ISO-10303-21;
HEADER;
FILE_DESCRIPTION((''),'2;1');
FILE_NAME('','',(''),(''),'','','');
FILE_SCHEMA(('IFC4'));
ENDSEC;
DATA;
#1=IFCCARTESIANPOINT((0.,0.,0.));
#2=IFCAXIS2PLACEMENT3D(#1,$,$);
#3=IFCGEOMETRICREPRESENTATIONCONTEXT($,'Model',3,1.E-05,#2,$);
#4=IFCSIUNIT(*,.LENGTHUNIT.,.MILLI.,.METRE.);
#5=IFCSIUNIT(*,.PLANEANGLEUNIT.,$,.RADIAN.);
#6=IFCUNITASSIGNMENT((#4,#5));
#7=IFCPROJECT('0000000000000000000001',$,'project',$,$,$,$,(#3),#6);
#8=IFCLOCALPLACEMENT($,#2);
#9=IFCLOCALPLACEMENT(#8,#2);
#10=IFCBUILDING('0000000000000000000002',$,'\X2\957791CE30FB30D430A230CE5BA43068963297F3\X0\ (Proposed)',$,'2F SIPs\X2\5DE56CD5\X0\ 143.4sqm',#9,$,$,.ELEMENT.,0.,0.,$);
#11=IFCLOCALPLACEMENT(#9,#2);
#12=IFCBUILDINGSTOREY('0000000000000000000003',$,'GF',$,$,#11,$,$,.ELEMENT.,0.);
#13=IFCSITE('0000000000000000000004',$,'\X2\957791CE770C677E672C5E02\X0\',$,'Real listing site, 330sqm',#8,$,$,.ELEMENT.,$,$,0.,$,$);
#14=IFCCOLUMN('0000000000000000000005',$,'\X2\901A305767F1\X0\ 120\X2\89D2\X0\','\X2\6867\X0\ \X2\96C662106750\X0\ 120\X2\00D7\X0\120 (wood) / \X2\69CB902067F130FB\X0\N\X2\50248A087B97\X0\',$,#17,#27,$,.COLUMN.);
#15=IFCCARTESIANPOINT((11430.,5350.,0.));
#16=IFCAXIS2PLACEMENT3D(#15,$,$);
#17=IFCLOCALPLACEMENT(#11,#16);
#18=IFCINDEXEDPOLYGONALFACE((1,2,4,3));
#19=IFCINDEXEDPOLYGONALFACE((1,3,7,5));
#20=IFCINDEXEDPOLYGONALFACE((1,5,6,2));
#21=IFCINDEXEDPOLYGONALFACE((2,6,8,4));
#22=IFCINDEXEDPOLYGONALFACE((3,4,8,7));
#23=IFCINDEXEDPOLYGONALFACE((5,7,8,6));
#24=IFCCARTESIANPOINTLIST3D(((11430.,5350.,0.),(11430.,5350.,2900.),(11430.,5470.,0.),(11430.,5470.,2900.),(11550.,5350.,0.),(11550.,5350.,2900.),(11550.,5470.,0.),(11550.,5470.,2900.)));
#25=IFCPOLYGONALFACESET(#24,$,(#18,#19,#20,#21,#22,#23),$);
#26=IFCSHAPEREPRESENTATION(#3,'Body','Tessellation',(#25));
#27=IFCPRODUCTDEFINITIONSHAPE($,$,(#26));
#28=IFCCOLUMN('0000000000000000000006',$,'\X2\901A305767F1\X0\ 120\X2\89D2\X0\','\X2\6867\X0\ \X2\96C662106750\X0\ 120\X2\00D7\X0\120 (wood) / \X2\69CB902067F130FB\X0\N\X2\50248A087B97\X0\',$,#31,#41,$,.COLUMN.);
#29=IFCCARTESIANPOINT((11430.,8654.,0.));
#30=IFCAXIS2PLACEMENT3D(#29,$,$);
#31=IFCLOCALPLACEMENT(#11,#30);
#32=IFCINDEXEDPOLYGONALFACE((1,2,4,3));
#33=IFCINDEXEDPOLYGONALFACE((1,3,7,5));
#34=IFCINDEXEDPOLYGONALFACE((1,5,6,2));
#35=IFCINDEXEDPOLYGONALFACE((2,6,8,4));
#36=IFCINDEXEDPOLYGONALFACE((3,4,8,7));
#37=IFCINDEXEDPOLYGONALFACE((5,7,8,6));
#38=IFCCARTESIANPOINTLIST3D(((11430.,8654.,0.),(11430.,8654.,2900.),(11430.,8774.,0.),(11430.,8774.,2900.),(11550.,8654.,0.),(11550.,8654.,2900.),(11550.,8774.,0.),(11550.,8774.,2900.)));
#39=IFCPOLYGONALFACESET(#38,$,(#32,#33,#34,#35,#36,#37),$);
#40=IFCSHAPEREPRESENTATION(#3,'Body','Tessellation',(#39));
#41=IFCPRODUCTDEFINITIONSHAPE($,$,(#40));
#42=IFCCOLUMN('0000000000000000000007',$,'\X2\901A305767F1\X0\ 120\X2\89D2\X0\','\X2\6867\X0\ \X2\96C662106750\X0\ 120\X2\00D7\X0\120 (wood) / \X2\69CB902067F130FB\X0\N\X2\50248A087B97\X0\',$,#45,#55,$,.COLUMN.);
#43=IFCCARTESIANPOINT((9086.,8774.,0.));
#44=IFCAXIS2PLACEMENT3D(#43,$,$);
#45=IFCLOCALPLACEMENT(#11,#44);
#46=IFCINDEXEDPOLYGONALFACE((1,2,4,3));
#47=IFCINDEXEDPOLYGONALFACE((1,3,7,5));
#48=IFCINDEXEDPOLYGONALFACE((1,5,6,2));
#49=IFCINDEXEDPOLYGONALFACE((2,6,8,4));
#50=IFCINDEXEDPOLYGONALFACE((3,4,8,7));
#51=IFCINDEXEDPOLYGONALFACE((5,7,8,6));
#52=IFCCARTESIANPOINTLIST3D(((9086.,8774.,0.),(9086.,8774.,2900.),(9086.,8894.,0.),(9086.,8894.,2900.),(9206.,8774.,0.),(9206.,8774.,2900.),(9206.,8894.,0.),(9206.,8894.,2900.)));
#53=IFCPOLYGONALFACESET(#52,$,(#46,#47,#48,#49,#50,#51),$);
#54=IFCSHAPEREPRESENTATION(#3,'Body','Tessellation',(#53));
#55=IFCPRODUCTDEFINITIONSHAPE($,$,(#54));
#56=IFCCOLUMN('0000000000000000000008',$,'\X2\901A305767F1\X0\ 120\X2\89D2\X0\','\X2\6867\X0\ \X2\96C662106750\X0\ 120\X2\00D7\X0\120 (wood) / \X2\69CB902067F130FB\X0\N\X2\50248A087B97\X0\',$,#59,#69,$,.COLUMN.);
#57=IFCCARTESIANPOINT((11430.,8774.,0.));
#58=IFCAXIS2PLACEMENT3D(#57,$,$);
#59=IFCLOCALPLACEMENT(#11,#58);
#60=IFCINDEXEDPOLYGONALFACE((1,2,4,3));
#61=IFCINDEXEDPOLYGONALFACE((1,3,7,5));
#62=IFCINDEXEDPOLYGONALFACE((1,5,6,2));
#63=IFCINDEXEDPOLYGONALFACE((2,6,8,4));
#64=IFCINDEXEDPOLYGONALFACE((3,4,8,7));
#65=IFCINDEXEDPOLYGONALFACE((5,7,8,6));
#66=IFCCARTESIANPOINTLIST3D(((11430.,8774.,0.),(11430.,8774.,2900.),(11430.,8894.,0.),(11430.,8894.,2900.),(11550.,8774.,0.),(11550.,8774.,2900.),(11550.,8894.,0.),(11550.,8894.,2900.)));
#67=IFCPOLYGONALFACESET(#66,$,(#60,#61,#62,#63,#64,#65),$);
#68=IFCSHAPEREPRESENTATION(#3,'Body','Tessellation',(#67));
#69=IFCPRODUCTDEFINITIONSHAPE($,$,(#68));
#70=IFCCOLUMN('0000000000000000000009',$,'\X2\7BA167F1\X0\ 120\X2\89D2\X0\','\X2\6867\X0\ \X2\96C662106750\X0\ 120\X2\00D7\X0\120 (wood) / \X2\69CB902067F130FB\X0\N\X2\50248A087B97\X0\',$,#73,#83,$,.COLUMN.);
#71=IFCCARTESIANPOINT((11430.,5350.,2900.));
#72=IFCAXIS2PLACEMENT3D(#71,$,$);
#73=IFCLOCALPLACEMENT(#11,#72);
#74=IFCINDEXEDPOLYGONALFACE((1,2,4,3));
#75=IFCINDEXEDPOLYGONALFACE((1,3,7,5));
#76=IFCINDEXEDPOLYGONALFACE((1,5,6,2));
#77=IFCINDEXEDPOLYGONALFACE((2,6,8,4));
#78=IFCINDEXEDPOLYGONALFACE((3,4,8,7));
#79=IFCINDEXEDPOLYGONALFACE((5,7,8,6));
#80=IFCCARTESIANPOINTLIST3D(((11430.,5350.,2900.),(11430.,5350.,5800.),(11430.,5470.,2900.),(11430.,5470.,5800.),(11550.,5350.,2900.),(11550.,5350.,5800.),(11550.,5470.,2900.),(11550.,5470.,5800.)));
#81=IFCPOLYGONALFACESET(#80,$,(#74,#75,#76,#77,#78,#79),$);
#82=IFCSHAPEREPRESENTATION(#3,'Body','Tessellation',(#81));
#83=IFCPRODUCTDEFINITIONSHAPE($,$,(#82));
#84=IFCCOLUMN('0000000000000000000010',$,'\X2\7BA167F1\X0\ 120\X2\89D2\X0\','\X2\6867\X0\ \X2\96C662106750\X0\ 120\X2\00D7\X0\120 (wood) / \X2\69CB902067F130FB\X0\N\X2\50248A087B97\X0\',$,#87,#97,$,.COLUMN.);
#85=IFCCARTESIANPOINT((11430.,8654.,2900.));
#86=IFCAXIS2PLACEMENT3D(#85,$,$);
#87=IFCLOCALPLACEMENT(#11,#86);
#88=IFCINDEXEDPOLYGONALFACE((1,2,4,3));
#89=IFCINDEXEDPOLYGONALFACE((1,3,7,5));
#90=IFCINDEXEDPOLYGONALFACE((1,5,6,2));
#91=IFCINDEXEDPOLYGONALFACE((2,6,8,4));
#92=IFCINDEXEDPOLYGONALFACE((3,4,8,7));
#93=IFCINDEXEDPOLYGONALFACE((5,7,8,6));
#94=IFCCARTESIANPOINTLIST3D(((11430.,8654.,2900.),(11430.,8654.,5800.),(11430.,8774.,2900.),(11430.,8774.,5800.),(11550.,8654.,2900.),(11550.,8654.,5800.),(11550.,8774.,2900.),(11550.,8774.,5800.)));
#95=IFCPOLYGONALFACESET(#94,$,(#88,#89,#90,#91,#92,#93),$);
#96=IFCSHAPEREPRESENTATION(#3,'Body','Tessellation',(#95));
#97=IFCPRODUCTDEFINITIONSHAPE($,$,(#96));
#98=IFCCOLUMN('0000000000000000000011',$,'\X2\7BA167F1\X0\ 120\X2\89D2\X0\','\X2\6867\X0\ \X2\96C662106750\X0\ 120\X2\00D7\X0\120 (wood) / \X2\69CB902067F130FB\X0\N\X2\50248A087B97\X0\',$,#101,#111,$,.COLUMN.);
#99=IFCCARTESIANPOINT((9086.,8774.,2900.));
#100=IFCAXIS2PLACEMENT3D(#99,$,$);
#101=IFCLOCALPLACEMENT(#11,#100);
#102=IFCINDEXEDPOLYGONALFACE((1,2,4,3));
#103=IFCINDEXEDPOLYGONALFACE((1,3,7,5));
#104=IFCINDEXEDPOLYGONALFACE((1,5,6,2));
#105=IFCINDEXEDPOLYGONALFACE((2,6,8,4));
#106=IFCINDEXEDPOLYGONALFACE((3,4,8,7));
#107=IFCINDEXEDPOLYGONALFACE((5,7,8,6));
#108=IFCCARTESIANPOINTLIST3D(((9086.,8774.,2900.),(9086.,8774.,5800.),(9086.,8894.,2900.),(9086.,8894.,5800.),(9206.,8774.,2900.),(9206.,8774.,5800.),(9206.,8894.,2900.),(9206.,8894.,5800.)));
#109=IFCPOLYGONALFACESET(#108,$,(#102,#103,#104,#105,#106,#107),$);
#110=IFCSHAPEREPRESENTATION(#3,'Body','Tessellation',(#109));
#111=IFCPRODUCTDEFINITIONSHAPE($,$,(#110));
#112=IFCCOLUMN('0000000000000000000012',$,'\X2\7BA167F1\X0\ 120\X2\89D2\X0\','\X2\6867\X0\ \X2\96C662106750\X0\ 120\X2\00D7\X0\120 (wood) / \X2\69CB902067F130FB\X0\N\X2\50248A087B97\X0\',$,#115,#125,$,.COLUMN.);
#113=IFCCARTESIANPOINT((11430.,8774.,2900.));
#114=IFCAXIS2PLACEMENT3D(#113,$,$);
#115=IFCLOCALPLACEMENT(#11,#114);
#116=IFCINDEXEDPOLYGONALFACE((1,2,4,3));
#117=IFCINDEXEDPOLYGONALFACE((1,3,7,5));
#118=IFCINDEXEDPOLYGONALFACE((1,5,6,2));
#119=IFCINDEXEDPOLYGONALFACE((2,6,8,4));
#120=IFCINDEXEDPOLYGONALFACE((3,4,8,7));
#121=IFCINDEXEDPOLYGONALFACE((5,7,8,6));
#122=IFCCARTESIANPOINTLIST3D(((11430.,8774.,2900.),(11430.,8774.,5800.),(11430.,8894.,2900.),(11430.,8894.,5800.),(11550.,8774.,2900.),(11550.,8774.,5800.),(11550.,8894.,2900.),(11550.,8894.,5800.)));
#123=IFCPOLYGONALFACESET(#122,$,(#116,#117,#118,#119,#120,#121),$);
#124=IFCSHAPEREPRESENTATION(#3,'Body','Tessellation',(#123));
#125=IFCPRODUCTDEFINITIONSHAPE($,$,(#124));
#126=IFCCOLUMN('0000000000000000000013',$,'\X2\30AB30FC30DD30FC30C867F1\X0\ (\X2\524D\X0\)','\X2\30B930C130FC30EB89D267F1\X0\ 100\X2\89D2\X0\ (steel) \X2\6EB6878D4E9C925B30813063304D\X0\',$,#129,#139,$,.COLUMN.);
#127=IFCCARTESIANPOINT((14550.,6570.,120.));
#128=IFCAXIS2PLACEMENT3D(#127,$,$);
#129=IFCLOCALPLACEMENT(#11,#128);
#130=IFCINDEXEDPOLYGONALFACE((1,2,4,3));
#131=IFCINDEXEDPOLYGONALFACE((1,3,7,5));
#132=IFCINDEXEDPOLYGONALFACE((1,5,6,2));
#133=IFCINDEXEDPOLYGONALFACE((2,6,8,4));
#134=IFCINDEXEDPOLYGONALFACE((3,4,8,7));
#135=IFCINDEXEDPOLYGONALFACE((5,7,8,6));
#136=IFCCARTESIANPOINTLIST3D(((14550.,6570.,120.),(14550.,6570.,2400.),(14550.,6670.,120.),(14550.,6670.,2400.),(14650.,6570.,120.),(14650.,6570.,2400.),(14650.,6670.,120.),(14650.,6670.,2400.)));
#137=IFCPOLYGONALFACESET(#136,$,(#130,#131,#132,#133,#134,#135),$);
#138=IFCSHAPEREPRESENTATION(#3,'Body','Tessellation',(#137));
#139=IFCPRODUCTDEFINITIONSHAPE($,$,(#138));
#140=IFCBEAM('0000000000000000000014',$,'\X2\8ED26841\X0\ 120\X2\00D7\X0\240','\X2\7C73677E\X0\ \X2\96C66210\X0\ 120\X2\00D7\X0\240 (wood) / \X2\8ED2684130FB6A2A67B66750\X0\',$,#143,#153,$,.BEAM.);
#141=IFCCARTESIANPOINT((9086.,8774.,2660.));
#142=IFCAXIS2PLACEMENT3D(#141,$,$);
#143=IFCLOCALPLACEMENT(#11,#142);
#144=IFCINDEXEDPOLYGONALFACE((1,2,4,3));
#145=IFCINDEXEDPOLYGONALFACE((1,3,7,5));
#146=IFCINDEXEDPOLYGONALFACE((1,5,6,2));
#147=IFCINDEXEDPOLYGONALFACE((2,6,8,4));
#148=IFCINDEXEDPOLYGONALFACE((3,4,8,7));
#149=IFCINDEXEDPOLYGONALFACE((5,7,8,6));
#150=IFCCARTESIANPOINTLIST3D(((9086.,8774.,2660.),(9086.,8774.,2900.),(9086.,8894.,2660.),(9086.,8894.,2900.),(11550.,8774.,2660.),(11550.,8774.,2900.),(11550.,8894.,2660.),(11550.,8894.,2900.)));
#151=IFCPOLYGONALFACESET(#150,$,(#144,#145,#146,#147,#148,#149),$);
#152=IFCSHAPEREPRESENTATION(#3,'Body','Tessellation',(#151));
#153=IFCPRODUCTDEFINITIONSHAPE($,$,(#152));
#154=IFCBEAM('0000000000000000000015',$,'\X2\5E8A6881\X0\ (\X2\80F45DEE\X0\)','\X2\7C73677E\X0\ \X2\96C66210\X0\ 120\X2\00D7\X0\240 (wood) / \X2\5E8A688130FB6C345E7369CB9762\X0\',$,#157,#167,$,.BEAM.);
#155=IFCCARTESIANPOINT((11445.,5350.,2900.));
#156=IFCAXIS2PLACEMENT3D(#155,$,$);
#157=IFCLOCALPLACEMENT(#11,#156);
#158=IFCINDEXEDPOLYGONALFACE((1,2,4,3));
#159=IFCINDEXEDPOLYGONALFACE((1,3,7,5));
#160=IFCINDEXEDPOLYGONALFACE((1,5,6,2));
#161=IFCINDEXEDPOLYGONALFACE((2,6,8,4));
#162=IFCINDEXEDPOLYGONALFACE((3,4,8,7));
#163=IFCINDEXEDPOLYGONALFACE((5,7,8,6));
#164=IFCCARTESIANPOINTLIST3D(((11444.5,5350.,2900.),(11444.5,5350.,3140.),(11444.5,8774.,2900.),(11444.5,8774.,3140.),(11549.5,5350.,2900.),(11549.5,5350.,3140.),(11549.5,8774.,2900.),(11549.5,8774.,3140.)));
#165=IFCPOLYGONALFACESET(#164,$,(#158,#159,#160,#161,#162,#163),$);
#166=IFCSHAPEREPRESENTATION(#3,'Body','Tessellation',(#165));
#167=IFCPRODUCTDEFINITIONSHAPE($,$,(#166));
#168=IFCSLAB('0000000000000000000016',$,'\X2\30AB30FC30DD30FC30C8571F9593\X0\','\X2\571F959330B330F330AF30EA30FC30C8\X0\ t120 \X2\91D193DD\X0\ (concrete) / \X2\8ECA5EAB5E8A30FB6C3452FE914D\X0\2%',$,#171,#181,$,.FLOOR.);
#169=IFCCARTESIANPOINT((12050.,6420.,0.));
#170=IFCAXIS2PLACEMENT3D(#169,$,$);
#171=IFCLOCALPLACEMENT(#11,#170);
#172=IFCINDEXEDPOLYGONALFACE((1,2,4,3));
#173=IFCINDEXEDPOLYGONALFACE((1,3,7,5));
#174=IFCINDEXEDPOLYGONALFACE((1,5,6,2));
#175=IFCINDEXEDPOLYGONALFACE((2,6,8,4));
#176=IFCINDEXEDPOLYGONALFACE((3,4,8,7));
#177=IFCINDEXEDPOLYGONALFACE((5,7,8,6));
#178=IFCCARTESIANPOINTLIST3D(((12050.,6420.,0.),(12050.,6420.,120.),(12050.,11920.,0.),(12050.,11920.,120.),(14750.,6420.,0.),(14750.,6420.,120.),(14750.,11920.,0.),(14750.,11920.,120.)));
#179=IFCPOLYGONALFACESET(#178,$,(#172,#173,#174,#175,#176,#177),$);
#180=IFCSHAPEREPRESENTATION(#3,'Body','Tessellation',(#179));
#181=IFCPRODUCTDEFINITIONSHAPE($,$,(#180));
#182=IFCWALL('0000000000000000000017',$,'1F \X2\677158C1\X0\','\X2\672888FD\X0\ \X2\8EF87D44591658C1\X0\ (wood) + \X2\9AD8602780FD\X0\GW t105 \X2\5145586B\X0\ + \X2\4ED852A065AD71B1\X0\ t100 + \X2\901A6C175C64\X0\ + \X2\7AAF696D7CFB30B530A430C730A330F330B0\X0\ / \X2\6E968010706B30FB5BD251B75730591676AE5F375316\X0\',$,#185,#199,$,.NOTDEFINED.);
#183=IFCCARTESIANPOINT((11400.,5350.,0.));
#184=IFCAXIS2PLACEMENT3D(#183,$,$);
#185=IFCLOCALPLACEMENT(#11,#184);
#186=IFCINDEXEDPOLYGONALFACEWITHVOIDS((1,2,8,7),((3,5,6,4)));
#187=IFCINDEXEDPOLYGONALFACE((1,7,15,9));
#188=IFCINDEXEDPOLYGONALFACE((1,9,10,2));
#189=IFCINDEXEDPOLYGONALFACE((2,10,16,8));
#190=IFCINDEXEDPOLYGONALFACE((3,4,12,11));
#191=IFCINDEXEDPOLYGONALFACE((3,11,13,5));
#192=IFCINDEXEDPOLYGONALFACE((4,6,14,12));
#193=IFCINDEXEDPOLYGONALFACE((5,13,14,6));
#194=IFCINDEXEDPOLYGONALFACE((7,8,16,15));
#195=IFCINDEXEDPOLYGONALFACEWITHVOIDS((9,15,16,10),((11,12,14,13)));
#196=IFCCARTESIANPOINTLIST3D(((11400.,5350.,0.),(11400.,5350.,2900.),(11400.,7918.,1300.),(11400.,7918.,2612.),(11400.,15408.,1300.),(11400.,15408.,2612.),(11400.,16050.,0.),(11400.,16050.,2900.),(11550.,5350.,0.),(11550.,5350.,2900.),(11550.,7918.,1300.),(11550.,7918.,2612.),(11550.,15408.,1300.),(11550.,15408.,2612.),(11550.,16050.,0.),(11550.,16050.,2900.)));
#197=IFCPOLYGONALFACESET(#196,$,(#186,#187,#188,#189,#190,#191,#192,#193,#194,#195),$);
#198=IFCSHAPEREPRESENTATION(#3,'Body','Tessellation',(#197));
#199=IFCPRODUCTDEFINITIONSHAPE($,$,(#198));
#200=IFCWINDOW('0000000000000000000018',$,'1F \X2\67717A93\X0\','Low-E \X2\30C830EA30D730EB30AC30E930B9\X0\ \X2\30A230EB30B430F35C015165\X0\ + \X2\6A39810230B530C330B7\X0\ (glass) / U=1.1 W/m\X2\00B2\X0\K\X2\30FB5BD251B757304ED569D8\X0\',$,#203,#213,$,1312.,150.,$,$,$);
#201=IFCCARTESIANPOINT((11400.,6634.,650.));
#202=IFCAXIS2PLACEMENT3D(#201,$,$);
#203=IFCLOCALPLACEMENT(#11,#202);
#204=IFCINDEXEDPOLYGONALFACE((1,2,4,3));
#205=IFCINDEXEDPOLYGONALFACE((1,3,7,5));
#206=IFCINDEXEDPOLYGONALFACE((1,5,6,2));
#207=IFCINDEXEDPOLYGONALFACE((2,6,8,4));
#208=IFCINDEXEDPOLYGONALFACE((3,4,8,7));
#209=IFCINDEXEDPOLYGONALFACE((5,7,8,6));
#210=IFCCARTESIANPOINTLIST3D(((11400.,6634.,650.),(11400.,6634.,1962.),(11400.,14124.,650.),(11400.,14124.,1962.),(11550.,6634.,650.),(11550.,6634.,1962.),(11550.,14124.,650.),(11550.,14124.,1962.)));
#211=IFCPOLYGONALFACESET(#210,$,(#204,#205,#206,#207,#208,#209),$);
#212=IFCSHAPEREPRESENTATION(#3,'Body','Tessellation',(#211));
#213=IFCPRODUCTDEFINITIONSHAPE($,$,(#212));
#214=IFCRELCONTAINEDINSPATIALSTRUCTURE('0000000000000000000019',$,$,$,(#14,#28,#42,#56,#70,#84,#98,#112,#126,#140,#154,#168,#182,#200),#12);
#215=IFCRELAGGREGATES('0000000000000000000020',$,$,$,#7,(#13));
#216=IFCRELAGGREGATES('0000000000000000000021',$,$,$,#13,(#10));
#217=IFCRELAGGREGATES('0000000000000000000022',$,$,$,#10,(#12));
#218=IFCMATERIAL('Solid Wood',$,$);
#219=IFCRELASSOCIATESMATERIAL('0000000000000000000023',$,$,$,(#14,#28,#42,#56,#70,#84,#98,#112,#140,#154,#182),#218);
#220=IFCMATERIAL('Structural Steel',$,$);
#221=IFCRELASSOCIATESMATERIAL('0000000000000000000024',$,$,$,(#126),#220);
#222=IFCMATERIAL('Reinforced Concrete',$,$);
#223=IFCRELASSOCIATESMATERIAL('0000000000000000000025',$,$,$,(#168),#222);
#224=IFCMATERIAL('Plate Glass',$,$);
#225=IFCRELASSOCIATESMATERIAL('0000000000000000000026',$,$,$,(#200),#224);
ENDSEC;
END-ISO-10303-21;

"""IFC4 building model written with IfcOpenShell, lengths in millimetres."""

from ifc_helpers import new_model, si_unit, frame, frame_2d, origin, place, context, project, spatial, rectangle, extrude, material, element, fill, save


model = new_model("IFC4")

# Units and contexts
model_context = context("Model", 3, precision=1e-05, world=origin())
ifc_project = project(units=[si_unit("LENGTHUNIT", "METRE", prefix="MILLI"), si_unit("PLANEANGLEUNIT", "RADIAN")], contexts=[model_context])

# Site, building, storey
site_placement = place(None, origin())
site = spatial("IfcSite", under=ifc_project, at=site_placement, Name="長野県松本市", ObjectType="Real listing site, 330sqm", CompositionType="ELEMENT", RefElevation=0.0)
building_placement = place(site_placement, origin())
building = spatial("IfcBuilding", under=site, at=building_placement, Name="長野・ピアノ室と防音 (Proposed)", ObjectType="2F SIPs工法 143.4sqm", CompositionType="ELEMENT", ElevationOfRefHeight=0.0, ElevationOfTerrain=0.0)
storey_placement = place(building_placement, origin())
storey = spatial("IfcBuildingStorey", under=building, at=storey_placement, Name="GF", CompositionType="ELEMENT", Elevation=0.0)

# Columns
ifc_material_1 = material(Name="Solid Wood")
column_1_placement = place(storey_placement, frame((11430.0, 5350.0, 0.0)))
element("IfcColumn", 1, at=column_1_placement, inside=storey, material=ifc_material_1, Name="通し柱 120角", Description="桧 集成材 120×120 (wood) / 構造柱・N値計算", PredefinedType="COLUMN", context=model_context, shape_type="SweptSolid", body=[
    extrude(rectangle(XDim=120.0, YDim=120.0, at=frame_2d((60.0, 60.0))), frame((11430.0, 5350.0, 0.0)), (0.0, 0.0, 1.0), 2900.0),
])
column_2_placement = place(storey_placement, frame((11430.0, 8654.0, 0.0)))
element("IfcColumn", 2, at=column_2_placement, inside=storey, material=ifc_material_1, Name="通し柱 120角", Description="桧 集成材 120×120 (wood) / 構造柱・N値計算", PredefinedType="COLUMN", context=model_context, shape_type="SweptSolid", body=[
    extrude(rectangle(XDim=120.0, YDim=120.0, at=frame_2d((60.0, 60.0))), frame((11430.0, 8654.0, 0.0)), (0.0, 0.0, 1.0), 2900.0),
])
column_3_placement = place(storey_placement, frame((9086.0, 8774.0, 0.0)))
element("IfcColumn", 3, at=column_3_placement, inside=storey, material=ifc_material_1, Name="通し柱 120角", Description="桧 集成材 120×120 (wood) / 構造柱・N値計算", PredefinedType="COLUMN", context=model_context, shape_type="SweptSolid", body=[
    extrude(rectangle(XDim=120.0, YDim=120.0, at=frame_2d((60.0, 60.0))), frame((9086.0, 8774.0, 0.0)), (0.0, 0.0, 1.0), 2900.0),
])
column_4_placement = place(storey_placement, frame((11430.0, 8774.0, 0.0)))
element("IfcColumn", 4, at=column_4_placement, inside=storey, material=ifc_material_1, Name="通し柱 120角", Description="桧 集成材 120×120 (wood) / 構造柱・N値計算", PredefinedType="COLUMN", context=model_context, shape_type="SweptSolid", body=[
    extrude(rectangle(XDim=120.0, YDim=120.0, at=frame_2d((60.0, 60.0))), frame((11430.0, 8774.0, 0.0)), (0.0, 0.0, 1.0), 2900.0),
])
column_5_placement = place(storey_placement, frame((11430.0, 5350.0, 2900.0)))
element("IfcColumn", 5, at=column_5_placement, inside=storey, material=ifc_material_1, Name="管柱 120角", Description="桧 集成材 120×120 (wood) / 構造柱・N値計算", PredefinedType="COLUMN", context=model_context, shape_type="SweptSolid", body=[
    extrude(rectangle(XDim=120.0, YDim=120.0, at=frame_2d((60.0, 60.0))), frame((11430.0, 5350.0, 2900.0)), (0.0, 0.0, 1.0), 2900.0),
])
column_6_placement = place(storey_placement, frame((11430.0, 8654.0, 2900.0)))
element("IfcColumn", 6, at=column_6_placement, inside=storey, material=ifc_material_1, Name="管柱 120角", Description="桧 集成材 120×120 (wood) / 構造柱・N値計算", PredefinedType="COLUMN", context=model_context, shape_type="SweptSolid", body=[
    extrude(rectangle(XDim=120.0, YDim=120.0, at=frame_2d((60.0, 60.0))), frame((11430.0, 8654.0, 2900.0)), (0.0, 0.0, 1.0), 2900.0),
])
column_7_placement = place(storey_placement, frame((9086.0, 8774.0, 2900.0)))
element("IfcColumn", 7, at=column_7_placement, inside=storey, material=ifc_material_1, Name="管柱 120角", Description="桧 集成材 120×120 (wood) / 構造柱・N値計算", PredefinedType="COLUMN", context=model_context, shape_type="SweptSolid", body=[
    extrude(rectangle(XDim=120.0, YDim=120.0, at=frame_2d((60.0, 60.0))), frame((9086.0, 8774.0, 2900.0)), (0.0, 0.0, 1.0), 2900.0),
])
column_8_placement = place(storey_placement, frame((11430.0, 8774.0, 2900.0)))
element("IfcColumn", 8, at=column_8_placement, inside=storey, material=ifc_material_1, Name="管柱 120角", Description="桧 集成材 120×120 (wood) / 構造柱・N値計算", PredefinedType="COLUMN", context=model_context, shape_type="SweptSolid", body=[
    extrude(rectangle(XDim=120.0, YDim=120.0, at=frame_2d((60.0, 60.0))), frame((11430.0, 8774.0, 2900.0)), (0.0, 0.0, 1.0), 2900.0),
])
ifc_material_2 = material(Name="Structural Steel")
column_9_placement = place(storey_placement, frame((14550.0, 6570.0, 120.0)))
element("IfcColumn", 9, at=column_9_placement, inside=storey, material=ifc_material_2, Name="カーポート柱 (前)", Description="スチール角柱 100角 (steel) 溶融亜鉛めっき", PredefinedType="COLUMN", context=model_context, shape_type="SweptSolid", body=[
    extrude(rectangle(XDim=100.0, YDim=100.0, at=frame_2d((50.0, 50.0))), frame((14550.0, 6570.0, 120.0)), (0.0, 0.0, 1.0), 2280.0),
])

# Beams
beam_1_placement = place(storey_placement, frame((9086.0, 8774.0, 2660.0)))
element("IfcBeam", 10, at=beam_1_placement, inside=storey, material=ifc_material_1, Name="軒桁 120×240", Description="米松 集成 120×240 (wood) / 軒桁・横架材", PredefinedType="BEAM", context=model_context, shape_type="SweptSolid", body=[
    extrude(rectangle(XDim=2464.0, YDim=120.0, at=frame_2d((1232.0, 60.0))), frame((9086.0, 8774.0, 2660.0)), (0.0, 0.0, 1.0), 240.0),
])
beam_2_placement = place(storey_placement, frame((11445.0, 5350.0, 2900.0)))
element("IfcBeam", 11, at=beam_2_placement, inside=storey, material=ifc_material_1, Name="床梁 (胴差)", Description="米松 集成 120×240 (wood) / 床梁・水平構面", PredefinedType="BEAM", context=model_context, shape_type="SweptSolid", body=[
    extrude(rectangle(XDim=105.0, YDim=3424.0, at=frame_2d((52.0, 1712.0))), frame((11445.0, 5350.0, 2900.0)), (0.0, 0.0, 1.0), 240.0),
])

# Slab
ifc_material_3 = material(Name="Reinforced Concrete")
slab_placement = place(storey_placement, frame((12050.0, 6420.0, 0.0)))
element("IfcSlab", 12, at=slab_placement, inside=storey, material=ifc_material_3, Name="カーポート土間", Description="土間コンクリート t120 金鏝 (concrete) / 車庫床・水勾配2%", PredefinedType="FLOOR", context=model_context, shape_type="SweptSolid", body=[
    extrude(rectangle(XDim=2700.0, YDim=5500.0, at=frame_2d((1350.0, 2750.0))), frame((12050.0, 6420.0, 0.0)), (0.0, 0.0, 1.0), 120.0),
])

# Wall, opening, window
wall_1_placement = place(storey_placement, frame((11400.0, 5350.0, 0.0)))
wall_1 = element("IfcWall", 13, at=wall_1_placement, inside=storey, material=ifc_material_1, Name="1F 東壁", Description="木製 軸組外壁 (wood) + 高性能GW t105 充填 + 付加断熱 t100 + 通気層 + 窯業系サイディング / 準耐火・寒冷地外皮強化", PredefinedType="NOTDEFINED", context=model_context, shape_type="SweptSolid", body=[
    extrude(rectangle(XDim=150.0, YDim=10700.0, at=frame_2d((75.0, 5350.0))), frame((11400.0, 5350.0, 0.0)), (0.0, 0.0, 1.0), 2900.0),
])
opening_1_placement = place(storey_placement, frame((11400.0, 6634.0, 650.0)))
opening_1 = element("IfcOpeningElement", 14, at=opening_1_placement, cuts=wall_1, PredefinedType="NOTDEFINED", context=model_context, shape_type="SweptSolid", body=[
    extrude(rectangle(XDim=150.0, YDim=7490.0, at=frame_2d((75.0, 3745.0))), frame((11400.0, 6634.0, 650.0)), (0.0, 0.0, 1.0), 1312.0),
])
ifc_material_4 = material(Name="Plate Glass")
window_1_placement = place(storey_placement, frame((11400.0, 6634.0, 650.0)))
window_1 = element("IfcWindow", 15, at=window_1_placement, inside=storey, material=ifc_material_4, Name="1F 東窓", Description="Low-E トリプルガラス アルゴン封入 + 樹脂サッシ (glass) / U=1.1 W/m²K・寒冷地仕様", OverallHeight=1312.0, OverallWidth=150.0, context=model_context, shape_type="SweptSolid", body=[
    extrude(rectangle(XDim=150.0, YDim=7490.0, at=frame_2d((75.0, 3745.0))), frame((11400.0, 6634.0, 650.0)), (0.0, 0.0, 1.0), 1312.0),
])
fill(opening_1, window_1)

save(model, "model.ifc")
